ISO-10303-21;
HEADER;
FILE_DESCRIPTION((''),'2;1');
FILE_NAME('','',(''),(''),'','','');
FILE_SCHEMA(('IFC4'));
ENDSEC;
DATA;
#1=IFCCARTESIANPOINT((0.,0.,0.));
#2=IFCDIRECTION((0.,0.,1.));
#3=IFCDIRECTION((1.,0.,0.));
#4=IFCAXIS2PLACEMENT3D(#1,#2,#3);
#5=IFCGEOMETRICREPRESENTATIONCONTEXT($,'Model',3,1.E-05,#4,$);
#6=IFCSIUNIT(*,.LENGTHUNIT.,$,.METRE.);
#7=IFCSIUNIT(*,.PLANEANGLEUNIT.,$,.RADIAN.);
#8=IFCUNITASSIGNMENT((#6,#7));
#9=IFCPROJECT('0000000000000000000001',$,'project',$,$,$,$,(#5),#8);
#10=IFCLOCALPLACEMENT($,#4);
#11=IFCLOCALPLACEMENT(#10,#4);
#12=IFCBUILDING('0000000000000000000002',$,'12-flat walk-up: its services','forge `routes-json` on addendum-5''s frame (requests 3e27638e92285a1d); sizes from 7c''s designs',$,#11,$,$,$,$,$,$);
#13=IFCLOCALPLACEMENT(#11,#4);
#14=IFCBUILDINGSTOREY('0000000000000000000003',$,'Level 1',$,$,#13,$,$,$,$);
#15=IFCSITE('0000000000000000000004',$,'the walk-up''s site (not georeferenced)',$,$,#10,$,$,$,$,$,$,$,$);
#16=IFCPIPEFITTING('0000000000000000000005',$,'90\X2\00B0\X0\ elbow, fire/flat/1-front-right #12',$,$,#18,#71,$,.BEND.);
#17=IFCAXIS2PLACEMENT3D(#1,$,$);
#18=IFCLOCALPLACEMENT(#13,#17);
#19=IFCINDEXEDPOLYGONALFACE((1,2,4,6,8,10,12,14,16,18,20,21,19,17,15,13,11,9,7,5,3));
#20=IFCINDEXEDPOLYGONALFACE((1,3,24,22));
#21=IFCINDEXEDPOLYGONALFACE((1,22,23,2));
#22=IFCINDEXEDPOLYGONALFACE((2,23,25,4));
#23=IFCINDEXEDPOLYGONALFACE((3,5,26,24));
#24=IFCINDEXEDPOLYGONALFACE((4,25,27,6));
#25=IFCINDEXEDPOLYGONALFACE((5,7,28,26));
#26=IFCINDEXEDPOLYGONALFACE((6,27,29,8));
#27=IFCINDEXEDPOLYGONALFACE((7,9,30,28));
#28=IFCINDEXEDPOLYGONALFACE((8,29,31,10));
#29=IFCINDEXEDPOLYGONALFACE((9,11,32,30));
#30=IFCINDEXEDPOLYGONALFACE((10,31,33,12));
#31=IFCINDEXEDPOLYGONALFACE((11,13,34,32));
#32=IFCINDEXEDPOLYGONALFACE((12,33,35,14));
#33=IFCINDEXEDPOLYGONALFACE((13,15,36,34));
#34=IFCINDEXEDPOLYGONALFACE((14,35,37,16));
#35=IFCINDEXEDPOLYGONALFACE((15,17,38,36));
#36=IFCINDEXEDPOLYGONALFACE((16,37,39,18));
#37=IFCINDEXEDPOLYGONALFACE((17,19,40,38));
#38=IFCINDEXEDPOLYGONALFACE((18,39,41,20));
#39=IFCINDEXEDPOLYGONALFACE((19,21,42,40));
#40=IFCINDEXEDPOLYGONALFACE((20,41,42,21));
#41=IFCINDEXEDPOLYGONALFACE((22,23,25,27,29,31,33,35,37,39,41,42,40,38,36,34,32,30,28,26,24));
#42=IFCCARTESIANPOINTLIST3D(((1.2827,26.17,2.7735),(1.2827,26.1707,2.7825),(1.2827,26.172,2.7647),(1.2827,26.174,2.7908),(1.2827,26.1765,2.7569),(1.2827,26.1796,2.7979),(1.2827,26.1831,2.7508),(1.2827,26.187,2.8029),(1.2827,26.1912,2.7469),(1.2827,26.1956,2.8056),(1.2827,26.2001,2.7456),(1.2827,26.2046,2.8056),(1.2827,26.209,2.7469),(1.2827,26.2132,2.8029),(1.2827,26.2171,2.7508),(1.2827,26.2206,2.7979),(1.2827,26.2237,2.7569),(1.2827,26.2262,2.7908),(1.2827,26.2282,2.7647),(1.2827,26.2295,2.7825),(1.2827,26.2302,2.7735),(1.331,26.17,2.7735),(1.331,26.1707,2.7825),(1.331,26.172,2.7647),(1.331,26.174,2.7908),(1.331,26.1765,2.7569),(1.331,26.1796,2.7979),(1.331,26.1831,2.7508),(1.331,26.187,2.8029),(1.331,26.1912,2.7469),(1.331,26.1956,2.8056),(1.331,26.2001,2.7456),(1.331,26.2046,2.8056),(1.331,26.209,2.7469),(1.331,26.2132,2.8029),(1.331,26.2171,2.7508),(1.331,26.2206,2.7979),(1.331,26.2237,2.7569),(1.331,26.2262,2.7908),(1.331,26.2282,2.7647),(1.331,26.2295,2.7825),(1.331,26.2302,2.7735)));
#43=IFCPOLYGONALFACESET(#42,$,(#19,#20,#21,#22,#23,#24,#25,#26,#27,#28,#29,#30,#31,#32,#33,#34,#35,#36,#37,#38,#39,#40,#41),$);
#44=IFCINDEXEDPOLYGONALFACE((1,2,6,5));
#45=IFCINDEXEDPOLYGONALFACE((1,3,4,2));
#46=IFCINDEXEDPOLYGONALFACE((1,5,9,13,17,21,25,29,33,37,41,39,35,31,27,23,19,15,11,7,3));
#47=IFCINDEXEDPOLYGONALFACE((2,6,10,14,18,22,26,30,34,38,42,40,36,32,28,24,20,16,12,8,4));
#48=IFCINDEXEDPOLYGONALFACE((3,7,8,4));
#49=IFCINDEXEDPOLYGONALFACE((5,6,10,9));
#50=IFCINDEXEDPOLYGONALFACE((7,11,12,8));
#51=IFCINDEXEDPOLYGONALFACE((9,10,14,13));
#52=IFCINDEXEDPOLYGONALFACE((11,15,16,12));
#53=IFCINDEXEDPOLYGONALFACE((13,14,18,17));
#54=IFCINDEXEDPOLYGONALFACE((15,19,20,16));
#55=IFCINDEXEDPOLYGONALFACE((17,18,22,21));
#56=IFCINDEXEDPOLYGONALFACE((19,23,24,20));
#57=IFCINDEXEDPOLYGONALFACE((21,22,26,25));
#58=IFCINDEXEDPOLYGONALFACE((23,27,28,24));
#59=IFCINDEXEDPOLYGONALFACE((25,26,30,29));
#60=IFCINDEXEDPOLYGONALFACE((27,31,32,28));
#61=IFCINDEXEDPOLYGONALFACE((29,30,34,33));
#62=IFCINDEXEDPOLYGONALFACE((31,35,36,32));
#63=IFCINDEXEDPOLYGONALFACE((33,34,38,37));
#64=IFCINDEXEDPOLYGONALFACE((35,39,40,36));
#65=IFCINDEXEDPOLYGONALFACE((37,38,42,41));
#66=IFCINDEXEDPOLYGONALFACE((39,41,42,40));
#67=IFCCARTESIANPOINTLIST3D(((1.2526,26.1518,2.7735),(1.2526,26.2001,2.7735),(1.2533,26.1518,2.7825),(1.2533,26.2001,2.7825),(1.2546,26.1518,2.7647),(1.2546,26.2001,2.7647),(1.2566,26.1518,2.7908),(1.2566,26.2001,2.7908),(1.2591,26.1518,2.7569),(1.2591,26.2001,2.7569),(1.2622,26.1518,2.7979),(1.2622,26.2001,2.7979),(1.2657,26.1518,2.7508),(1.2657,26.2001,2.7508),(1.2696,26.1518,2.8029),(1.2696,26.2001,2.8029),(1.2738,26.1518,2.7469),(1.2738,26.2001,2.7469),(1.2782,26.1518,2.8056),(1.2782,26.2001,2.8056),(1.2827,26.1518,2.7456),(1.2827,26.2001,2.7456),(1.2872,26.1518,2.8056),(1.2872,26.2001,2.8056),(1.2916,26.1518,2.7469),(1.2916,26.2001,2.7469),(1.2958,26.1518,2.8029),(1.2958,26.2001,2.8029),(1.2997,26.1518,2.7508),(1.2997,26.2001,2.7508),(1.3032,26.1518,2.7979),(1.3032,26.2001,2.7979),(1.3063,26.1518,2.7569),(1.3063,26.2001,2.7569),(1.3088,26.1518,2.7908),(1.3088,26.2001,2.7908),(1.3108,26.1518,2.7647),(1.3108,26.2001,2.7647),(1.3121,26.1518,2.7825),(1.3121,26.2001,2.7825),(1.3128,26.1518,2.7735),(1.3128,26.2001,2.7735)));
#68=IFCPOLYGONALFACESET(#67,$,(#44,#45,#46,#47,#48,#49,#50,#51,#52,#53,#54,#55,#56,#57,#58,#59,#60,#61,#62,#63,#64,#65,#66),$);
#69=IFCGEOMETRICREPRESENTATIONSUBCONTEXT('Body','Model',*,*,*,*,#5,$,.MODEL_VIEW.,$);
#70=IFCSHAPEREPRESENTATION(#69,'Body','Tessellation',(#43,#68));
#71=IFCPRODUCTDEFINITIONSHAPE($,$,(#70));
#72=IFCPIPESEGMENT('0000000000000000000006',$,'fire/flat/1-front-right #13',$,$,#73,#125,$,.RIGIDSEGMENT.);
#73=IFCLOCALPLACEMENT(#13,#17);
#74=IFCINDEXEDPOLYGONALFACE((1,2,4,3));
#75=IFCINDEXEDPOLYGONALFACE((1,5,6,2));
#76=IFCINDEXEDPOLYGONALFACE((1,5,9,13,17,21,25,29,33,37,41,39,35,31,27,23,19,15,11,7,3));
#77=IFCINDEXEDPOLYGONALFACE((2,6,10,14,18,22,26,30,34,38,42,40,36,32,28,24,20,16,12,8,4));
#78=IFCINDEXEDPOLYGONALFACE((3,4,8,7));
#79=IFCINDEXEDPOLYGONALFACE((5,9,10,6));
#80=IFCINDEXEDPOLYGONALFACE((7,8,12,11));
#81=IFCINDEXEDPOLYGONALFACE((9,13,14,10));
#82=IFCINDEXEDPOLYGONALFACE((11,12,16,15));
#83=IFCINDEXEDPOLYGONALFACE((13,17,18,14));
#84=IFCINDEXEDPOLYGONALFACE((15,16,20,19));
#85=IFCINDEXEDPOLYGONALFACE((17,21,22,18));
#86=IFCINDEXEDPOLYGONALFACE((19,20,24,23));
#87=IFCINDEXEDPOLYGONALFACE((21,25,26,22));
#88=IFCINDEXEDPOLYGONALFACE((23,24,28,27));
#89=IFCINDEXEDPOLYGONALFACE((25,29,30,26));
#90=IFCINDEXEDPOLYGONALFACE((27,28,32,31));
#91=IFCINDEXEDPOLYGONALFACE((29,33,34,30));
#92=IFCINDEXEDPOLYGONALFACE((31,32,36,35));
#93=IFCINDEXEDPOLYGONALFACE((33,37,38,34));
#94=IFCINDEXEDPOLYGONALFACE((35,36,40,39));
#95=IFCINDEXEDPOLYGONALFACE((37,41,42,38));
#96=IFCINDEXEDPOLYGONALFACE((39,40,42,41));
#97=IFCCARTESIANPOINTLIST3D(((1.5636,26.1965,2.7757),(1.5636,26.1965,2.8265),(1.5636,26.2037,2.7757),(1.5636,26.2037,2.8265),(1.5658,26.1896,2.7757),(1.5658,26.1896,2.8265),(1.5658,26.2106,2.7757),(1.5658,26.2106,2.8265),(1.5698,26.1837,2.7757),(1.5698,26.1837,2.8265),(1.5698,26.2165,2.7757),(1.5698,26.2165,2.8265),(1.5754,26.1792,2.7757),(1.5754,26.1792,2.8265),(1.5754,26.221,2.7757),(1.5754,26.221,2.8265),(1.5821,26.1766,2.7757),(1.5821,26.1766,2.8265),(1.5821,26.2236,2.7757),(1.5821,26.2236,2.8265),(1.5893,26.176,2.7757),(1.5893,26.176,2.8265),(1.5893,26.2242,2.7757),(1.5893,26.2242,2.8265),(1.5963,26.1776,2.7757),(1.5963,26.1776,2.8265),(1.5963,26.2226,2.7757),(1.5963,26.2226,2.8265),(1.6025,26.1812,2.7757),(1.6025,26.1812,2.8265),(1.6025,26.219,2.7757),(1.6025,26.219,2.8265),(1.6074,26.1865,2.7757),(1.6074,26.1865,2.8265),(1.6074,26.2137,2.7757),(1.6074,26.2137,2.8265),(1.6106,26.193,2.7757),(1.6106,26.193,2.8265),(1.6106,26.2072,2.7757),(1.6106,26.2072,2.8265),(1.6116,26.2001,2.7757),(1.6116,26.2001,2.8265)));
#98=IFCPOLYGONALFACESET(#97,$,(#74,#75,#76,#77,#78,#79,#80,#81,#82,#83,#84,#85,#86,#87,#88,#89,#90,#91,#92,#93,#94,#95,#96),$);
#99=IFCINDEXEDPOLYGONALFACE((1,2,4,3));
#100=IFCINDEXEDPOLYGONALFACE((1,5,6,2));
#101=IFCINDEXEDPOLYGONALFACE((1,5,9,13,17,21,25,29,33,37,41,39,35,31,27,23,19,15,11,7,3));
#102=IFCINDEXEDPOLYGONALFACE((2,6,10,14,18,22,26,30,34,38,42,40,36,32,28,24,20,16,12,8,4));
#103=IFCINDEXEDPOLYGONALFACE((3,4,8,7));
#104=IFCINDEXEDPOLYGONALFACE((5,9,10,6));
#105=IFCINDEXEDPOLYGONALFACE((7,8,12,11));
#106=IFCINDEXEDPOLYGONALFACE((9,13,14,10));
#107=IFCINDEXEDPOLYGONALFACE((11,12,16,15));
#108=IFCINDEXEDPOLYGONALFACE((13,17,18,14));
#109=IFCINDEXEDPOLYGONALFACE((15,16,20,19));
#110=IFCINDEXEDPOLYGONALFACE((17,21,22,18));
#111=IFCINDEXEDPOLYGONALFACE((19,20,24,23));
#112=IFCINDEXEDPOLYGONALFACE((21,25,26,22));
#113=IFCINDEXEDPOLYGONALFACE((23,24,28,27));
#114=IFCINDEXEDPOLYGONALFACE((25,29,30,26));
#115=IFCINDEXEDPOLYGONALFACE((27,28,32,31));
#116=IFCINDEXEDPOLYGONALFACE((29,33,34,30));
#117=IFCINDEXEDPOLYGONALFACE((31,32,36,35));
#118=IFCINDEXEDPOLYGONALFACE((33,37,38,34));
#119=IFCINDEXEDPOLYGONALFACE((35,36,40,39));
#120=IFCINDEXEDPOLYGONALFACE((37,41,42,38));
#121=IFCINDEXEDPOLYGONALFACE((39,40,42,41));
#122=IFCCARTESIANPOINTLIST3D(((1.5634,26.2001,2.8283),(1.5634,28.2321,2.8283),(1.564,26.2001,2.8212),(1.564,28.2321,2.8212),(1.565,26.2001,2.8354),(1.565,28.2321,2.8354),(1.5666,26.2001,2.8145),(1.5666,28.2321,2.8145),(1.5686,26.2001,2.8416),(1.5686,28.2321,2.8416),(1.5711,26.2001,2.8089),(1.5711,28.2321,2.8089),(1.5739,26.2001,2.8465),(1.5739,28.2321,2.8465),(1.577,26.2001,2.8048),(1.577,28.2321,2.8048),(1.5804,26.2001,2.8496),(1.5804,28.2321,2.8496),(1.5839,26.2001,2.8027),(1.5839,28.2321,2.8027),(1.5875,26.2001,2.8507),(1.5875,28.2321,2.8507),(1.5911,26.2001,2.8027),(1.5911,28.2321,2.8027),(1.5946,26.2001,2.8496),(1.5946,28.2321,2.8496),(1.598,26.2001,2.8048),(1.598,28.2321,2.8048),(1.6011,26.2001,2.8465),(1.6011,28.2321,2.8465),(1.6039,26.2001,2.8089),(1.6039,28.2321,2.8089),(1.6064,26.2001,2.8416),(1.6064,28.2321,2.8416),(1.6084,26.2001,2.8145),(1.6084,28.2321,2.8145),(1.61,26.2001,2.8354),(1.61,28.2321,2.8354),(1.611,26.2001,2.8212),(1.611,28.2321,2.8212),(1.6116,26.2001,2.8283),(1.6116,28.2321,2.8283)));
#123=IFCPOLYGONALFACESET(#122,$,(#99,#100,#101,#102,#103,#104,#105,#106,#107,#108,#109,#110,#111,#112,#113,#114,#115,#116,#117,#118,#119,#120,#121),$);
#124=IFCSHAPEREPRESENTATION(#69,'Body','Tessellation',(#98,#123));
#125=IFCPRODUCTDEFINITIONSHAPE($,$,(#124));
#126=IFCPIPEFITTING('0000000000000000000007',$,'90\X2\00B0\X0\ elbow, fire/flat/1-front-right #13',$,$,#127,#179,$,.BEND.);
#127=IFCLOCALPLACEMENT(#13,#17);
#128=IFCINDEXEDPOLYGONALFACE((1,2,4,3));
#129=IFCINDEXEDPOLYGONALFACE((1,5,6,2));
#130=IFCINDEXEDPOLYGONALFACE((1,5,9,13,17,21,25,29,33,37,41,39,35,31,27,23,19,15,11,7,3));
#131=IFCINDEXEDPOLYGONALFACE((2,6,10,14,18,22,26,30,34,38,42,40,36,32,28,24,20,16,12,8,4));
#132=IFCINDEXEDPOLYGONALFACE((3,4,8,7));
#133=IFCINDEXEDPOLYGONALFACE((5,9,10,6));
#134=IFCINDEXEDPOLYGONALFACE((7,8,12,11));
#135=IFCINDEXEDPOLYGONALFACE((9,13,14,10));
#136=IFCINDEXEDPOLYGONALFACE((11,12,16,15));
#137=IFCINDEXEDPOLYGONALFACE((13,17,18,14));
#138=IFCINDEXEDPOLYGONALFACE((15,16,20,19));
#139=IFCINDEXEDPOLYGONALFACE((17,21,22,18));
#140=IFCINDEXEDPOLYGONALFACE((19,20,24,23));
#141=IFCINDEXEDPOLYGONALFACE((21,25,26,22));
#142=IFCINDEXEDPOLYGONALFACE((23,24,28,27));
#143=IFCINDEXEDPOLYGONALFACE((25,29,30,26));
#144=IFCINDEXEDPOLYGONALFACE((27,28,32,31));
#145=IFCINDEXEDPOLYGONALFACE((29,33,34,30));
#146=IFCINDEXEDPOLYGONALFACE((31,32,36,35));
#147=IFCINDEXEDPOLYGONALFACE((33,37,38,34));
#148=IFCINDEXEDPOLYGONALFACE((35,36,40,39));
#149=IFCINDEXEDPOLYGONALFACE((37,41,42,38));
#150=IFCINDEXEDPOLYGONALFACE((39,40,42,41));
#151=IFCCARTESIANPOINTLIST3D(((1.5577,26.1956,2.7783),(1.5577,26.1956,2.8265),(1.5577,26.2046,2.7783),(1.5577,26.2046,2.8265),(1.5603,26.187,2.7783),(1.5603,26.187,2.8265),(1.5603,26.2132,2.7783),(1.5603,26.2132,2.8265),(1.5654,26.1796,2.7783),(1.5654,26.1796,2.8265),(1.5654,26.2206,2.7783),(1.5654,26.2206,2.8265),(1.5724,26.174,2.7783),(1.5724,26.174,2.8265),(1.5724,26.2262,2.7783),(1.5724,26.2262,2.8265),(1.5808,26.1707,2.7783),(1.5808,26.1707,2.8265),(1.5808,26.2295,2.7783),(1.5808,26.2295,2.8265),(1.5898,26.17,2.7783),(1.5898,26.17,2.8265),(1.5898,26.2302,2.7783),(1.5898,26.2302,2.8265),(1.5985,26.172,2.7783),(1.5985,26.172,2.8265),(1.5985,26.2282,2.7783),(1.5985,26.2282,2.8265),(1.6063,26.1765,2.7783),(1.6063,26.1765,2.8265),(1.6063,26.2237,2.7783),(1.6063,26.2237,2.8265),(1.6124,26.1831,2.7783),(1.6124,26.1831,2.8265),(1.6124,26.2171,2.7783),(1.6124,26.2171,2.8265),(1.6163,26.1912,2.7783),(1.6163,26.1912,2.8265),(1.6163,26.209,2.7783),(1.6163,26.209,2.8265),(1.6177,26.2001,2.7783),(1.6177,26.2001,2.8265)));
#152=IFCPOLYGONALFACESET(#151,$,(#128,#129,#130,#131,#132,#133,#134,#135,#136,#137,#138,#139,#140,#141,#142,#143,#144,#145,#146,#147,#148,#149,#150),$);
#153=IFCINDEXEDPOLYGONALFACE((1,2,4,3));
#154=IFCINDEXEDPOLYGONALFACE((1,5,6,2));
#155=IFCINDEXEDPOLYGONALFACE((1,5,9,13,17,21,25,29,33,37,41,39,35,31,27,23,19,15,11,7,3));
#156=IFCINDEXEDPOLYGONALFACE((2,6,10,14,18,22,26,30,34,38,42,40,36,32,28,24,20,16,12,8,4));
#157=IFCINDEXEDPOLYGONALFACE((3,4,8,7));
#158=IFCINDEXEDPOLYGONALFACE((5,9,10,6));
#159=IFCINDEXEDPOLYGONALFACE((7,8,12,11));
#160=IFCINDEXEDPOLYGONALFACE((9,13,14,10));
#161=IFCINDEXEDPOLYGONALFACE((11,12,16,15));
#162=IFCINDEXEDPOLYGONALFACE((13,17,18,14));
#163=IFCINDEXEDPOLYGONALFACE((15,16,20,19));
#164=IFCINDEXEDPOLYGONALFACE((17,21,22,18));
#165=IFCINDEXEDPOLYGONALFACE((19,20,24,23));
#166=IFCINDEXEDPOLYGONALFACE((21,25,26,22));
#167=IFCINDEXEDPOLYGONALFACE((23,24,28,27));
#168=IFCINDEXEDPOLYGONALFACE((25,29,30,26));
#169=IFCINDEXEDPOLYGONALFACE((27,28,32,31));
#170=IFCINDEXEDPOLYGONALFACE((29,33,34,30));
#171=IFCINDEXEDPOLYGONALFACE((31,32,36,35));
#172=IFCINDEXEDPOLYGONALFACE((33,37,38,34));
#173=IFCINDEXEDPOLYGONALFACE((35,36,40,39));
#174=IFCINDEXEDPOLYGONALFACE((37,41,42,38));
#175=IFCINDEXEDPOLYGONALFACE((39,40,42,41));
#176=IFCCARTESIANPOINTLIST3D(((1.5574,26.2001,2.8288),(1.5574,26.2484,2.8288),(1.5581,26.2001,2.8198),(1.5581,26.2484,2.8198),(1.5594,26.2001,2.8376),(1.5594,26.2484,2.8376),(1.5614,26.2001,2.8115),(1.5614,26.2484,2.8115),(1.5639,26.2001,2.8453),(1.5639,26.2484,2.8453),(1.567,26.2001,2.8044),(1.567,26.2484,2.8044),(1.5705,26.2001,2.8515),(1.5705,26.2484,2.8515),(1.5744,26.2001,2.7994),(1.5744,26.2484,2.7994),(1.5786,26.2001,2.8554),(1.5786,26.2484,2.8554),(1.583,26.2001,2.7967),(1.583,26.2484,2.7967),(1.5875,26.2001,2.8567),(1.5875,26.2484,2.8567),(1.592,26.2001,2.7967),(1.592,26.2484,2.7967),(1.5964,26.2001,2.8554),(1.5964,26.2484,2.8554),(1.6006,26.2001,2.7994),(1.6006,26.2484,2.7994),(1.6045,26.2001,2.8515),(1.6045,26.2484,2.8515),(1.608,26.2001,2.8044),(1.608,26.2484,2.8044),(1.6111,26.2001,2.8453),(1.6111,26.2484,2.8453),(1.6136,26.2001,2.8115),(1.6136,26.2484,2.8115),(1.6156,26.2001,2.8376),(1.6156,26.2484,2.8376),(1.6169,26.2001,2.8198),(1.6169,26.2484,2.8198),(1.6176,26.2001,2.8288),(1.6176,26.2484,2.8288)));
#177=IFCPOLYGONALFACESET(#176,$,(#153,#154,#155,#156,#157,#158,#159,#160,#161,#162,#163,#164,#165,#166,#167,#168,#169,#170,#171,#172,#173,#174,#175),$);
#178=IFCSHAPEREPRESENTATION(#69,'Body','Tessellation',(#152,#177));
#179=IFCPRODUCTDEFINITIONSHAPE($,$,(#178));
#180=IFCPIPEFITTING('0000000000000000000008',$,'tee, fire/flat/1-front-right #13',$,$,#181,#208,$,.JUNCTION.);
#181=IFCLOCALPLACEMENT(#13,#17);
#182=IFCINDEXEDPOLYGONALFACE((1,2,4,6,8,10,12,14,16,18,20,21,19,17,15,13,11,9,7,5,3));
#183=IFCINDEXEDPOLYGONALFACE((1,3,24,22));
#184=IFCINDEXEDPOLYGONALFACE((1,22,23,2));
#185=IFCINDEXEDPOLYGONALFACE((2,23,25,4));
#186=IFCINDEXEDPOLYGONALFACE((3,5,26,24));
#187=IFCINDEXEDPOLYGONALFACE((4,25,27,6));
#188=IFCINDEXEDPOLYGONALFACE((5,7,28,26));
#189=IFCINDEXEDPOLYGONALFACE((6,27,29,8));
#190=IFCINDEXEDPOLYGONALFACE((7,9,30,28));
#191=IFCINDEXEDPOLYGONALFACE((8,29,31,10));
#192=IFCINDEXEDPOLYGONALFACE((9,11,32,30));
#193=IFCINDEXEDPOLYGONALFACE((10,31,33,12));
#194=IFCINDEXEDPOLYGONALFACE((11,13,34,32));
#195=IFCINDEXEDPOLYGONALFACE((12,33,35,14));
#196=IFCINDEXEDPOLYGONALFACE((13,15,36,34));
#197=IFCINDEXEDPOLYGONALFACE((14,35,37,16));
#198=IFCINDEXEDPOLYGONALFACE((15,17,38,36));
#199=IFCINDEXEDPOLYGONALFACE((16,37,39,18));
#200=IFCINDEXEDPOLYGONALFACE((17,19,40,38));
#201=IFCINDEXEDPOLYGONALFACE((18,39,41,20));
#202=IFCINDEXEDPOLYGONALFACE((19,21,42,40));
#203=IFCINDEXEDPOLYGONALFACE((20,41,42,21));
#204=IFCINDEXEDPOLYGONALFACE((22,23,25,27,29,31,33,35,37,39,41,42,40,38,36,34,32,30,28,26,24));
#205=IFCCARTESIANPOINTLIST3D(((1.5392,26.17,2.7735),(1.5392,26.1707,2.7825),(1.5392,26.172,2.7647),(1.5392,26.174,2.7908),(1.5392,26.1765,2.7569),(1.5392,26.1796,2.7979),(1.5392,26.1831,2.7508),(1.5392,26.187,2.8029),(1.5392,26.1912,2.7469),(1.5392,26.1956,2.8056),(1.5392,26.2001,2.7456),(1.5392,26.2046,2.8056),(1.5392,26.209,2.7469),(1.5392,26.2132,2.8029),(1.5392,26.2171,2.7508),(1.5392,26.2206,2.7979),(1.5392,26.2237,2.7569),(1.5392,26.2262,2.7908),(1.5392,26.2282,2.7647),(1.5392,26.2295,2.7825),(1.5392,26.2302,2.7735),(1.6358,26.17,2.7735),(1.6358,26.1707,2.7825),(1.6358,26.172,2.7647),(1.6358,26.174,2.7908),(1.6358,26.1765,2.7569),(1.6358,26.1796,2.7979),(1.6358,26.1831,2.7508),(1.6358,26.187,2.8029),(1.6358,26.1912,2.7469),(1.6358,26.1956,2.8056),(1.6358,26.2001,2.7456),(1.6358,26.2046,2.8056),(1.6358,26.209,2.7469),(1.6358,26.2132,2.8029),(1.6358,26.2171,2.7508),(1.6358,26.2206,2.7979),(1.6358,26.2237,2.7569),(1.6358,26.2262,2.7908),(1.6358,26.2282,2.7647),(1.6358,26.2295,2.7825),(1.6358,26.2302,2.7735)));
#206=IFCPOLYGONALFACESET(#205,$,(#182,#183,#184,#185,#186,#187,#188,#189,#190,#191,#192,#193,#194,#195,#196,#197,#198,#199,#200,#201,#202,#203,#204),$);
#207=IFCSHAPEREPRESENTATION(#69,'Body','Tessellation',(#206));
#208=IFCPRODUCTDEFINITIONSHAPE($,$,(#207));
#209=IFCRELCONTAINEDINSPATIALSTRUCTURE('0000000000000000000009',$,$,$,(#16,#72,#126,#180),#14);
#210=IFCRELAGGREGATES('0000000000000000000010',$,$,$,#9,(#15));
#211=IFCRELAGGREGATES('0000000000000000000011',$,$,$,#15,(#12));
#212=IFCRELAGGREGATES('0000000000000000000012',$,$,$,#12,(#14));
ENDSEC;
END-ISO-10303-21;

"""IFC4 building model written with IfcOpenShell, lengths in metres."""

from ifc_helpers import new_model, entity, si_unit, frame, origin_with_axes, place, context, subcontext, project, spatial, element, save


model = new_model("IFC4")

# Units and contexts
model_context = context("Model", 3, precision=1e-05, world=origin_with_axes())
body_context = subcontext(model_context, "Body", "Model", "MODEL_VIEW")
ifc_project = project(units=[si_unit("LENGTHUNIT", "METRE"), si_unit("PLANEANGLEUNIT", "RADIAN")], contexts=[model_context])

# Site, building, storey
site_placement = place(None, origin_with_axes())
site = spatial("IfcSite", under=ifc_project, at=site_placement, Name="the walk-up's site (not georeferenced)")
building_placement = place(site_placement, origin_with_axes())
building = spatial("IfcBuilding", under=site, at=building_placement, Name="12-flat walk-up: its services", Description="forge `routes-json` on addendum-5's frame (requests 3e27638e92285a1d); sizes from 7c's designs")
storey_placement = place(building_placement, origin_with_axes())
storey = spatial("IfcBuildingStorey", under=building, at=storey_placement, Name="Level 1")

# Pipe fitting
pipe_fitting_1_placement = place(storey_placement, frame((1.331, 26.2001, 2.7757), z_axis=(0.0, 0.0, 1.0), x_axis=(1.0, 0.0, 0.0)))
element("IfcPipeFitting", 1, at=pipe_fitting_1_placement, inside=storey, Name="90° elbow, fire/flat/1-front-right #12", PredefinedType="BEND", context=body_context, shape_type="AdvancedSweptSolid", body=[
    entity("IfcSweptDiskSolid", entity("IfcPolyline", [entity("IfcCartesianPoint", [0.0, 0.0, 0.0]), entity("IfcCartesianPoint", [-0.0483, 0.0, 0.0])]), 0.0302),
    entity("IfcSweptDiskSolid", entity("IfcPolyline", [entity("IfcCartesianPoint", [-0.0483, 0.0, 0.0]), entity("IfcCartesianPoint", [-0.0483, -0.0483, 0.0])]), 0.0302),
])

# Pipe segment
pipe_segment_1_placement = place(storey_placement, frame((1.5875, 26.2001, 2.7757), z_axis=(0.0, 0.0, 1.0), x_axis=(1.0, 0.0, 0.0)))
element("IfcPipeSegment", 2, at=pipe_segment_1_placement, inside=storey, Name="fire/flat/1-front-right #13", PredefinedType="RIGIDSEGMENT", context=body_context, shape_type="AdvancedSweptSolid", body=[
    entity("IfcSweptDiskSolid", entity("IfcPolyline", [entity("IfcCartesianPoint", [0.0, 0.0, 0.0]), entity("IfcCartesianPoint", [0.0, 0.0, 0.0508])]), 0.0241),
    entity("IfcSweptDiskSolid", entity("IfcPolyline", [entity("IfcCartesianPoint", [0.0, 0.0, 0.0508]), entity("IfcCartesianPoint", [0.0, 2.032, 0.0508])]), 0.0241),
])

# Pipe fittings
pipe_fitting_2_placement = place(storey_placement, frame((1.5875, 26.2001, 2.7783), z_axis=(0.0, 0.0, 1.0), x_axis=(1.0, 0.0, 0.0)))
element("IfcPipeFitting", 3, at=pipe_fitting_2_placement, inside=storey, Name="90° elbow, fire/flat/1-front-right #13", PredefinedType="BEND", context=body_context, shape_type="AdvancedSweptSolid", body=[
    entity("IfcSweptDiskSolid", entity("IfcPolyline", [entity("IfcCartesianPoint", [0.0, 0.0, 0.0]), entity("IfcCartesianPoint", [0.0, 0.0, 0.0483])]), 0.0302),
    entity("IfcSweptDiskSolid", entity("IfcPolyline", [entity("IfcCartesianPoint", [0.0, 0.0, 0.0483]), entity("IfcCartesianPoint", [0.0, 0.0483, 0.0483])]), 0.0302),
])
pipe_fitting_3_placement = place(storey_placement, frame((1.6358, 26.2001, 2.7757), z_axis=(0.0, 0.0, 1.0), x_axis=(1.0, 0.0, 0.0)))
element("IfcPipeFitting", 4, at=pipe_fitting_3_placement, inside=storey, Name="tee, fire/flat/1-front-right #13", PredefinedType="JUNCTION", context=body_context, shape_type="AdvancedSweptSolid", body=[
    entity("IfcSweptDiskSolid", entity("IfcPolyline", [entity("IfcCartesianPoint", [0.0, 0.0, 0.0]), entity("IfcCartesianPoint", [-0.0965, 0.0, 0.0])]), 0.0302),
])

save(model, "model.ifc")
